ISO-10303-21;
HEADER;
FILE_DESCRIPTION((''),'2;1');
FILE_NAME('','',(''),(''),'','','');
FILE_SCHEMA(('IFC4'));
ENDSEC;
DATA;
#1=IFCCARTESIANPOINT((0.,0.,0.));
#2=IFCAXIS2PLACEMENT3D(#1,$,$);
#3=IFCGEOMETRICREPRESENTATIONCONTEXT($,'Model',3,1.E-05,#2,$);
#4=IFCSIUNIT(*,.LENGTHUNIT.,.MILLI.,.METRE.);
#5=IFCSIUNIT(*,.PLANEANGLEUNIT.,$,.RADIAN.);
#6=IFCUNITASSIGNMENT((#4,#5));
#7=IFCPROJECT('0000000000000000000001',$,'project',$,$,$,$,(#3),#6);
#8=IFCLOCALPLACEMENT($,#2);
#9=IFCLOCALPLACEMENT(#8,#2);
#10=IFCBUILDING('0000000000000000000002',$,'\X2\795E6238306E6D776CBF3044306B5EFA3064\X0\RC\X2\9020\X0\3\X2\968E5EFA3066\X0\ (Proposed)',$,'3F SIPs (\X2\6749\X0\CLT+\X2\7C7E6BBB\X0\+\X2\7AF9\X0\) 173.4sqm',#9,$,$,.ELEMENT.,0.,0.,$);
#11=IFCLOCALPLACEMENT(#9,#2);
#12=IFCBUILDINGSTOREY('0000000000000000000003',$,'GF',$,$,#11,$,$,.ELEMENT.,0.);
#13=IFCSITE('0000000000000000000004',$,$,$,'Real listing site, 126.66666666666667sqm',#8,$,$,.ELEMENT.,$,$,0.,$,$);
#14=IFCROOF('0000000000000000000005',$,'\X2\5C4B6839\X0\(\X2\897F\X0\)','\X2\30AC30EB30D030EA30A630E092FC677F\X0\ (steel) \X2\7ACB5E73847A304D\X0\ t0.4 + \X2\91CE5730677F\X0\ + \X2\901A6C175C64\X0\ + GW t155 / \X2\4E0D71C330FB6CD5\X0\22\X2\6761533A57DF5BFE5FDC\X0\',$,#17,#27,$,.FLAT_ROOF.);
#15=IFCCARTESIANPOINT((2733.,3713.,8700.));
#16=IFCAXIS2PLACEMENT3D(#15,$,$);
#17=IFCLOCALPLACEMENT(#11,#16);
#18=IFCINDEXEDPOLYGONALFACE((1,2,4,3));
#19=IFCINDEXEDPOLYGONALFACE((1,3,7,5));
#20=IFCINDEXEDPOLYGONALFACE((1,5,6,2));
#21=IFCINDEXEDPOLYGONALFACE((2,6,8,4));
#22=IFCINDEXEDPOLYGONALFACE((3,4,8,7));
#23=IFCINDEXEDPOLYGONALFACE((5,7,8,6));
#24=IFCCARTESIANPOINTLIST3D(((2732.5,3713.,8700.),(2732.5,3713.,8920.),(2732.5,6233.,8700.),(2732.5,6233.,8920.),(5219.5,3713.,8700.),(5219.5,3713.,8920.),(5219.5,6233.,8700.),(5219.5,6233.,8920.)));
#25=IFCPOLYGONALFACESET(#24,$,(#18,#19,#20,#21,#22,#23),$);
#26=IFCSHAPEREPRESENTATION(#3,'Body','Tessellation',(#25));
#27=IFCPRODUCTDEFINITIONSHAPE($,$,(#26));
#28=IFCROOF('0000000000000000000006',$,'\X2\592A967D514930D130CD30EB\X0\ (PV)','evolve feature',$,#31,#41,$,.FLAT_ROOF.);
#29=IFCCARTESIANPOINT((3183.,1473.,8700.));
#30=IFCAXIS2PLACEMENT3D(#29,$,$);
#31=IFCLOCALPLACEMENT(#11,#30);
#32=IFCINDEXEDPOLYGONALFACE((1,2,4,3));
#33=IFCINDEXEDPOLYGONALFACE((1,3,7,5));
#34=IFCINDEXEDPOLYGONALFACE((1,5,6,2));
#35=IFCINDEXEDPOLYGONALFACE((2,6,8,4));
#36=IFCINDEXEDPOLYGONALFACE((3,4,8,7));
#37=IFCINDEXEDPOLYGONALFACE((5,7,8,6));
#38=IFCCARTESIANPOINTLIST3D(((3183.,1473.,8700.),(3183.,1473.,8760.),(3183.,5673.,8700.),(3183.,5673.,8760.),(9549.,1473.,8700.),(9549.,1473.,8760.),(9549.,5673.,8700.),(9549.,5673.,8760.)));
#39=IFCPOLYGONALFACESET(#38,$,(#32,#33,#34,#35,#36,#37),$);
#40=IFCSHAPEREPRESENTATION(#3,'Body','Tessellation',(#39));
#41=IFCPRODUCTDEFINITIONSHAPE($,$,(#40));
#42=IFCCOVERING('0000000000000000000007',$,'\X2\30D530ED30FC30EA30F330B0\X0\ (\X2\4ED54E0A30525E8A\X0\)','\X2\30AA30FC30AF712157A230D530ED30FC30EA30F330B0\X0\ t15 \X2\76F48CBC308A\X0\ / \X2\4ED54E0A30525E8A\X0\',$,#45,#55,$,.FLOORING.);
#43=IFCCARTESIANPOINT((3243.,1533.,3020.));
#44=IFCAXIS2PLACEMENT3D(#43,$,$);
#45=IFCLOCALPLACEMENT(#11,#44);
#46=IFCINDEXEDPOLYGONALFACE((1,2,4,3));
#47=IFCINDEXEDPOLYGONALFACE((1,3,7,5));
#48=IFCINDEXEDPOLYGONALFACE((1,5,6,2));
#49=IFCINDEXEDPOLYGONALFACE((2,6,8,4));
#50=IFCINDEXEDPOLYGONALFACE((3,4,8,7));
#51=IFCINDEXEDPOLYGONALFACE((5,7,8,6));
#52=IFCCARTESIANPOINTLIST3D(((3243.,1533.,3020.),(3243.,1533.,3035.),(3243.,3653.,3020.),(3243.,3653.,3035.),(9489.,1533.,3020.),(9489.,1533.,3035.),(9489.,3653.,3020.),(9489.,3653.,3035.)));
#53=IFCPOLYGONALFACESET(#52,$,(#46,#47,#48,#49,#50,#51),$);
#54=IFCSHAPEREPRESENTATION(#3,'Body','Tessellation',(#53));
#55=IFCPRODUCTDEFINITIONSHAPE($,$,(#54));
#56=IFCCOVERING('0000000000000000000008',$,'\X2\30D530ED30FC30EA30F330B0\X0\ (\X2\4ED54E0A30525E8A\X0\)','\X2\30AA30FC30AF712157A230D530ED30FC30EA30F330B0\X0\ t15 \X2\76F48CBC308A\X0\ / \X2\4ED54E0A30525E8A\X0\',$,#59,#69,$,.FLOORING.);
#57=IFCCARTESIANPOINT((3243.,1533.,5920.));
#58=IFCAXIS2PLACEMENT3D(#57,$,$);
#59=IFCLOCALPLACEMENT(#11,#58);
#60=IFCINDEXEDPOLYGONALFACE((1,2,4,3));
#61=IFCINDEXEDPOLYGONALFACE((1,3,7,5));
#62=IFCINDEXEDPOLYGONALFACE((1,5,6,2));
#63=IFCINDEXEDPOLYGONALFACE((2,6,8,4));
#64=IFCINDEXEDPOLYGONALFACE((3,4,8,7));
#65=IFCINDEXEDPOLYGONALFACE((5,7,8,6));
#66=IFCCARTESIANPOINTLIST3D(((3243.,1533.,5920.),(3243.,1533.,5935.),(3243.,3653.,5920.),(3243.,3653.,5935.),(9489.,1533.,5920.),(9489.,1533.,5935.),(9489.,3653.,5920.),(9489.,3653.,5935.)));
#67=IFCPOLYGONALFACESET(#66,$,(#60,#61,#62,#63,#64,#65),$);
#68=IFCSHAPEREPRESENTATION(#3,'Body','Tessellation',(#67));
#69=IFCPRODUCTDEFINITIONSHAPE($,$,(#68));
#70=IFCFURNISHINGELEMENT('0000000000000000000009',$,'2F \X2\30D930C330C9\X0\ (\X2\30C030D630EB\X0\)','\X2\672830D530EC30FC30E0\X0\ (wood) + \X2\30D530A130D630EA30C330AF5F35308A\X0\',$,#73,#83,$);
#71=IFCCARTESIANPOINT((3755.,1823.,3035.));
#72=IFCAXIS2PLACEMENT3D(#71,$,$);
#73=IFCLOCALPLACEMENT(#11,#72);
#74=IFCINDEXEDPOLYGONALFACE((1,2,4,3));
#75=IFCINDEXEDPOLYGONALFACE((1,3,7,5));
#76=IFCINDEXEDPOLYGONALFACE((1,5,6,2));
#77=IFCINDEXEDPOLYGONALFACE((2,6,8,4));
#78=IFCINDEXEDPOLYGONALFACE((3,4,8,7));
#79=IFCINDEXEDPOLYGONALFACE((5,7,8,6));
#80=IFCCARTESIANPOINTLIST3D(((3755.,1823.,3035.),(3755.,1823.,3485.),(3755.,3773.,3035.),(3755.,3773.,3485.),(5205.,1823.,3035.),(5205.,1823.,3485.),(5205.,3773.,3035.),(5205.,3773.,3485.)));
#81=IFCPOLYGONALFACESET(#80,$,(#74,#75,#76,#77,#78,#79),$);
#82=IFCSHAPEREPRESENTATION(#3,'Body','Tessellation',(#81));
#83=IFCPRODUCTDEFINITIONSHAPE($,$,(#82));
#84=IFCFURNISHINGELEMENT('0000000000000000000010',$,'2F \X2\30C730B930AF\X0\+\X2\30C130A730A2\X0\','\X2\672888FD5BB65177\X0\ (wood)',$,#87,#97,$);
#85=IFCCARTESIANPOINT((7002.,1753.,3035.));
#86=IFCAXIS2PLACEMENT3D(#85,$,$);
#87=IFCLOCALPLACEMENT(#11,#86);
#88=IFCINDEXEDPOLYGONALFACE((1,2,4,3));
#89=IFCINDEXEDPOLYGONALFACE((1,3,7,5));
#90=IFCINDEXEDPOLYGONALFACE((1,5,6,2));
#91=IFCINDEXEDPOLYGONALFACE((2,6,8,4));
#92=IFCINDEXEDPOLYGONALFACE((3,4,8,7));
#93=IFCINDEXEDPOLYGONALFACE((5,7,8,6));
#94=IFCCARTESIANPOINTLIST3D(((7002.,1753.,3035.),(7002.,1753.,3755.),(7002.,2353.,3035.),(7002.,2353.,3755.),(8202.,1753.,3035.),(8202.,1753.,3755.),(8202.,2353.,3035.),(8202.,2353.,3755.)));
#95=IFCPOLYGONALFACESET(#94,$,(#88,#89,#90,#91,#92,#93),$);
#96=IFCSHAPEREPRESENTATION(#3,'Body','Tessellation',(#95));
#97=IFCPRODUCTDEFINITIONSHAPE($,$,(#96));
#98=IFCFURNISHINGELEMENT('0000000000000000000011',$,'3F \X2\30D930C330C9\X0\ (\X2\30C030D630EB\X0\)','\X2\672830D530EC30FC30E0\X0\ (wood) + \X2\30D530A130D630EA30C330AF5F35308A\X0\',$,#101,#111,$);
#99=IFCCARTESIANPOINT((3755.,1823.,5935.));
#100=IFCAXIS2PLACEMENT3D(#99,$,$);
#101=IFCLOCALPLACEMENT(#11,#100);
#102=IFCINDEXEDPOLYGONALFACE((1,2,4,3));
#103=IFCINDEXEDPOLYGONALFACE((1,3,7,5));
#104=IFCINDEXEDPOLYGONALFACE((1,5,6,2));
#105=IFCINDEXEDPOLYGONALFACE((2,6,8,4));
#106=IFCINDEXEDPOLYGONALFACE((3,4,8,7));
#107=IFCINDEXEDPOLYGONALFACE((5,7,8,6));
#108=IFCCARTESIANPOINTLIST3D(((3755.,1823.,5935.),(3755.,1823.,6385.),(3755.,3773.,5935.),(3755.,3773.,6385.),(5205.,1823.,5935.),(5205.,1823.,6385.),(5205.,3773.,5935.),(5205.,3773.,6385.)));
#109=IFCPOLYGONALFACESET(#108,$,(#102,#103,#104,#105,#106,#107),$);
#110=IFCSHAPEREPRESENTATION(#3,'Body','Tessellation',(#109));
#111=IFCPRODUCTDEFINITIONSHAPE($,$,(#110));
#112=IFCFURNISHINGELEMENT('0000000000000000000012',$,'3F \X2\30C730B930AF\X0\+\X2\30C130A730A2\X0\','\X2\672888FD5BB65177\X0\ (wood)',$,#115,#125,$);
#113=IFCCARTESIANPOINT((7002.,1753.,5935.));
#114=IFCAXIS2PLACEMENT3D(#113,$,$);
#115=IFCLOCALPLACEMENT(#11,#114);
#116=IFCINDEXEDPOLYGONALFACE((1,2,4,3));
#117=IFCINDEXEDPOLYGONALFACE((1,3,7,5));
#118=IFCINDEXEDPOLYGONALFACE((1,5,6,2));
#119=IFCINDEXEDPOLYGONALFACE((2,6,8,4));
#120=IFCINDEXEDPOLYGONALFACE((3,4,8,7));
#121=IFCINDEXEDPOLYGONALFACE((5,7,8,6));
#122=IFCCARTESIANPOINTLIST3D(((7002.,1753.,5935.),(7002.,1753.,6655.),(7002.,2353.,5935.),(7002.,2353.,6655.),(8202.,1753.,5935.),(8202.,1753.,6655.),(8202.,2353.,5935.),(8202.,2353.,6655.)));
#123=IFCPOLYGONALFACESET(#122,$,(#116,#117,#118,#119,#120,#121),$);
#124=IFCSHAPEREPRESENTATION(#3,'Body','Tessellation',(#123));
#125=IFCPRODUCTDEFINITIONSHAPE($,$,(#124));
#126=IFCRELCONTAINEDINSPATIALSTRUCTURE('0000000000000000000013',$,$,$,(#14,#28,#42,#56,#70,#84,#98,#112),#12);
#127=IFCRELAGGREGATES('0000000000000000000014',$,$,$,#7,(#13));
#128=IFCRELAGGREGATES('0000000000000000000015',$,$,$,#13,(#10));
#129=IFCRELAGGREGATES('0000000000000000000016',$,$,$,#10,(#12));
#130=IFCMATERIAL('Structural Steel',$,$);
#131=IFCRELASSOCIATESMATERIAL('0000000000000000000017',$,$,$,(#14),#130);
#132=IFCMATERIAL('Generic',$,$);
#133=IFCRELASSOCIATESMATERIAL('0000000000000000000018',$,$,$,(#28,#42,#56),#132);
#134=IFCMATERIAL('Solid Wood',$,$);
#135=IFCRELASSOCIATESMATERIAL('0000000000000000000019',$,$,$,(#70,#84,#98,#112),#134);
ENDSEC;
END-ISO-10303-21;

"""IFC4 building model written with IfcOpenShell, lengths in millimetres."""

from ifc_helpers import new_model, si_unit, frame, frame_2d, origin, place, context, project, spatial, rectangle, extrude, material, element, save


model = new_model("IFC4")

# Units and contexts
model_context = context("Model", 3, precision=1e-05, world=origin())
ifc_project = project(units=[si_unit("LENGTHUNIT", "METRE", prefix="MILLI"), si_unit("PLANEANGLEUNIT", "RADIAN")], contexts=[model_context])

# Site, building, storey
site_placement = place(None, origin())
site = spatial("IfcSite", under=ifc_project, at=site_placement, ObjectType="Real listing site, 126.66666666666667sqm", CompositionType="ELEMENT", RefElevation=0.0)
building_placement = place(site_placement, origin())
building = spatial("IfcBuilding", under=site, at=building_placement, Name="神戸の海沿いに建つRC造3階建て (Proposed)", ObjectType="3F SIPs (杉CLT+籾殻+竹) 173.4sqm", CompositionType="ELEMENT", ElevationOfRefHeight=0.0, ElevationOfTerrain=0.0)
storey_placement = place(building_placement, origin())
storey = spatial("IfcBuildingStorey", under=building, at=storey_placement, Name="GF", CompositionType="ELEMENT", Elevation=0.0)

# Shared definitions
ifc_material_1 = material(Name="Solid Wood")

# Roofs
ifc_material_2 = material(Name="Structural Steel")
roof_1_placement = place(storey_placement, frame((2733.0, 3713.0, 8700.0)))
element("IfcRoof", 1, at=roof_1_placement, inside=storey, material=ifc_material_2, Name="屋根(西)", Description="ガルバリウム鋼板 (steel) 立平葺き t0.4 + 野地板 + 通気層 + GW t155 / 不燃・法22条区域対応", PredefinedType="FLAT_ROOF", context=model_context, shape_type="SweptSolid", body=[
    extrude(rectangle(XDim=2487.0, YDim=2520.0, at=frame_2d((1243.0, 1260.0))), frame((2733.0, 3713.0, 8700.0)), (0.0, 0.0, 1.0), 220.0),
])
ifc_material_3 = material(Name="Generic")
roof_2_placement = place(storey_placement, frame((3183.0, 1473.0, 8700.0)))
element("IfcRoof", 2, at=roof_2_placement, inside=storey, material=ifc_material_3, Name="太陽光パネル (PV)", Description="evolve feature", PredefinedType="FLAT_ROOF", context=model_context, shape_type="SweptSolid", body=[
    extrude(rectangle(XDim=6366.0, YDim=4200.0, at=frame_2d((3183.0, 2100.0))), frame((3183.0, 1473.0, 8700.0)), (0.0, 0.0, 1.0), 60.0),
])

# Coverings
covering_1_placement = place(storey_placement, frame((3243.0, 1533.0, 3020.0)))
element("IfcCovering", 3, at=covering_1_placement, inside=storey, material=ifc_material_3, Name="フローリング (仕上げ床)", Description="オーク無垢フローリング t15 直貼り / 仕上げ床", PredefinedType="FLOORING", context=model_context, shape_type="SweptSolid", body=[
    extrude(rectangle(XDim=6246.0, YDim=2120.0, at=frame_2d((3123.0, 1060.0))), frame((3243.0, 1533.0, 3020.0)), (0.0, 0.0, 1.0), 15.0),
])
covering_2_placement = place(storey_placement, frame((3243.0, 1533.0, 5920.0)))
element("IfcCovering", 4, at=covering_2_placement, inside=storey, material=ifc_material_3, Name="フローリング (仕上げ床)", Description="オーク無垢フローリング t15 直貼り / 仕上げ床", PredefinedType="FLOORING", context=model_context, shape_type="SweptSolid", body=[
    extrude(rectangle(XDim=6246.0, YDim=2120.0, at=frame_2d((3123.0, 1060.0))), frame((3243.0, 1533.0, 5920.0)), (0.0, 0.0, 1.0), 15.0),
])

# Furnishing elements
furnishing_1_placement = place(storey_placement, frame((3755.0, 1823.0, 3035.0)))
element("IfcFurnishingElement", 5, at=furnishing_1_placement, inside=storey, material=ifc_material_1, Name="2F ベッド (ダブル)", Description="木フレーム (wood) + ファブリック張り", context=model_context, shape_type="SweptSolid", body=[
    extrude(rectangle(XDim=1450.0, YDim=1950.0, at=frame_2d((725.0, 975.0))), frame((3755.0, 1823.0, 3035.0)), (0.0, 0.0, 1.0), 450.0),
])
furnishing_2_placement = place(storey_placement, frame((7002.0, 1753.0, 3035.0)))
element("IfcFurnishingElement", 6, at=furnishing_2_placement, inside=storey, material=ifc_material_1, Name="2F デスク+チェア", Description="木製家具 (wood)", context=model_context, shape_type="SweptSolid", body=[
    extrude(rectangle(XDim=1200.0, YDim=600.0, at=frame_2d((600.0, 300.0))), frame((7002.0, 1753.0, 3035.0)), (0.0, 0.0, 1.0), 720.0),
])
furnishing_3_placement = place(storey_placement, frame((3755.0, 1823.0, 5935.0)))
element("IfcFurnishingElement", 7, at=furnishing_3_placement, inside=storey, material=ifc_material_1, Name="3F ベッド (ダブル)", Description="木フレーム (wood) + ファブリック張り", context=model_context, shape_type="SweptSolid", body=[
    extrude(rectangle(XDim=1450.0, YDim=1950.0, at=frame_2d((725.0, 975.0))), frame((3755.0, 1823.0, 5935.0)), (0.0, 0.0, 1.0), 450.0),
])
furnishing_4_placement = place(storey_placement, frame((7002.0, 1753.0, 5935.0)))
element("IfcFurnishingElement", 8, at=furnishing_4_placement, inside=storey, material=ifc_material_1, Name="3F デスク+チェア", Description="木製家具 (wood)", context=model_context, shape_type="SweptSolid", body=[
    extrude(rectangle(XDim=1200.0, YDim=600.0, at=frame_2d((600.0, 300.0))), frame((7002.0, 1753.0, 5935.0)), (0.0, 0.0, 1.0), 720.0),
])

save(model, "model.ifc")
